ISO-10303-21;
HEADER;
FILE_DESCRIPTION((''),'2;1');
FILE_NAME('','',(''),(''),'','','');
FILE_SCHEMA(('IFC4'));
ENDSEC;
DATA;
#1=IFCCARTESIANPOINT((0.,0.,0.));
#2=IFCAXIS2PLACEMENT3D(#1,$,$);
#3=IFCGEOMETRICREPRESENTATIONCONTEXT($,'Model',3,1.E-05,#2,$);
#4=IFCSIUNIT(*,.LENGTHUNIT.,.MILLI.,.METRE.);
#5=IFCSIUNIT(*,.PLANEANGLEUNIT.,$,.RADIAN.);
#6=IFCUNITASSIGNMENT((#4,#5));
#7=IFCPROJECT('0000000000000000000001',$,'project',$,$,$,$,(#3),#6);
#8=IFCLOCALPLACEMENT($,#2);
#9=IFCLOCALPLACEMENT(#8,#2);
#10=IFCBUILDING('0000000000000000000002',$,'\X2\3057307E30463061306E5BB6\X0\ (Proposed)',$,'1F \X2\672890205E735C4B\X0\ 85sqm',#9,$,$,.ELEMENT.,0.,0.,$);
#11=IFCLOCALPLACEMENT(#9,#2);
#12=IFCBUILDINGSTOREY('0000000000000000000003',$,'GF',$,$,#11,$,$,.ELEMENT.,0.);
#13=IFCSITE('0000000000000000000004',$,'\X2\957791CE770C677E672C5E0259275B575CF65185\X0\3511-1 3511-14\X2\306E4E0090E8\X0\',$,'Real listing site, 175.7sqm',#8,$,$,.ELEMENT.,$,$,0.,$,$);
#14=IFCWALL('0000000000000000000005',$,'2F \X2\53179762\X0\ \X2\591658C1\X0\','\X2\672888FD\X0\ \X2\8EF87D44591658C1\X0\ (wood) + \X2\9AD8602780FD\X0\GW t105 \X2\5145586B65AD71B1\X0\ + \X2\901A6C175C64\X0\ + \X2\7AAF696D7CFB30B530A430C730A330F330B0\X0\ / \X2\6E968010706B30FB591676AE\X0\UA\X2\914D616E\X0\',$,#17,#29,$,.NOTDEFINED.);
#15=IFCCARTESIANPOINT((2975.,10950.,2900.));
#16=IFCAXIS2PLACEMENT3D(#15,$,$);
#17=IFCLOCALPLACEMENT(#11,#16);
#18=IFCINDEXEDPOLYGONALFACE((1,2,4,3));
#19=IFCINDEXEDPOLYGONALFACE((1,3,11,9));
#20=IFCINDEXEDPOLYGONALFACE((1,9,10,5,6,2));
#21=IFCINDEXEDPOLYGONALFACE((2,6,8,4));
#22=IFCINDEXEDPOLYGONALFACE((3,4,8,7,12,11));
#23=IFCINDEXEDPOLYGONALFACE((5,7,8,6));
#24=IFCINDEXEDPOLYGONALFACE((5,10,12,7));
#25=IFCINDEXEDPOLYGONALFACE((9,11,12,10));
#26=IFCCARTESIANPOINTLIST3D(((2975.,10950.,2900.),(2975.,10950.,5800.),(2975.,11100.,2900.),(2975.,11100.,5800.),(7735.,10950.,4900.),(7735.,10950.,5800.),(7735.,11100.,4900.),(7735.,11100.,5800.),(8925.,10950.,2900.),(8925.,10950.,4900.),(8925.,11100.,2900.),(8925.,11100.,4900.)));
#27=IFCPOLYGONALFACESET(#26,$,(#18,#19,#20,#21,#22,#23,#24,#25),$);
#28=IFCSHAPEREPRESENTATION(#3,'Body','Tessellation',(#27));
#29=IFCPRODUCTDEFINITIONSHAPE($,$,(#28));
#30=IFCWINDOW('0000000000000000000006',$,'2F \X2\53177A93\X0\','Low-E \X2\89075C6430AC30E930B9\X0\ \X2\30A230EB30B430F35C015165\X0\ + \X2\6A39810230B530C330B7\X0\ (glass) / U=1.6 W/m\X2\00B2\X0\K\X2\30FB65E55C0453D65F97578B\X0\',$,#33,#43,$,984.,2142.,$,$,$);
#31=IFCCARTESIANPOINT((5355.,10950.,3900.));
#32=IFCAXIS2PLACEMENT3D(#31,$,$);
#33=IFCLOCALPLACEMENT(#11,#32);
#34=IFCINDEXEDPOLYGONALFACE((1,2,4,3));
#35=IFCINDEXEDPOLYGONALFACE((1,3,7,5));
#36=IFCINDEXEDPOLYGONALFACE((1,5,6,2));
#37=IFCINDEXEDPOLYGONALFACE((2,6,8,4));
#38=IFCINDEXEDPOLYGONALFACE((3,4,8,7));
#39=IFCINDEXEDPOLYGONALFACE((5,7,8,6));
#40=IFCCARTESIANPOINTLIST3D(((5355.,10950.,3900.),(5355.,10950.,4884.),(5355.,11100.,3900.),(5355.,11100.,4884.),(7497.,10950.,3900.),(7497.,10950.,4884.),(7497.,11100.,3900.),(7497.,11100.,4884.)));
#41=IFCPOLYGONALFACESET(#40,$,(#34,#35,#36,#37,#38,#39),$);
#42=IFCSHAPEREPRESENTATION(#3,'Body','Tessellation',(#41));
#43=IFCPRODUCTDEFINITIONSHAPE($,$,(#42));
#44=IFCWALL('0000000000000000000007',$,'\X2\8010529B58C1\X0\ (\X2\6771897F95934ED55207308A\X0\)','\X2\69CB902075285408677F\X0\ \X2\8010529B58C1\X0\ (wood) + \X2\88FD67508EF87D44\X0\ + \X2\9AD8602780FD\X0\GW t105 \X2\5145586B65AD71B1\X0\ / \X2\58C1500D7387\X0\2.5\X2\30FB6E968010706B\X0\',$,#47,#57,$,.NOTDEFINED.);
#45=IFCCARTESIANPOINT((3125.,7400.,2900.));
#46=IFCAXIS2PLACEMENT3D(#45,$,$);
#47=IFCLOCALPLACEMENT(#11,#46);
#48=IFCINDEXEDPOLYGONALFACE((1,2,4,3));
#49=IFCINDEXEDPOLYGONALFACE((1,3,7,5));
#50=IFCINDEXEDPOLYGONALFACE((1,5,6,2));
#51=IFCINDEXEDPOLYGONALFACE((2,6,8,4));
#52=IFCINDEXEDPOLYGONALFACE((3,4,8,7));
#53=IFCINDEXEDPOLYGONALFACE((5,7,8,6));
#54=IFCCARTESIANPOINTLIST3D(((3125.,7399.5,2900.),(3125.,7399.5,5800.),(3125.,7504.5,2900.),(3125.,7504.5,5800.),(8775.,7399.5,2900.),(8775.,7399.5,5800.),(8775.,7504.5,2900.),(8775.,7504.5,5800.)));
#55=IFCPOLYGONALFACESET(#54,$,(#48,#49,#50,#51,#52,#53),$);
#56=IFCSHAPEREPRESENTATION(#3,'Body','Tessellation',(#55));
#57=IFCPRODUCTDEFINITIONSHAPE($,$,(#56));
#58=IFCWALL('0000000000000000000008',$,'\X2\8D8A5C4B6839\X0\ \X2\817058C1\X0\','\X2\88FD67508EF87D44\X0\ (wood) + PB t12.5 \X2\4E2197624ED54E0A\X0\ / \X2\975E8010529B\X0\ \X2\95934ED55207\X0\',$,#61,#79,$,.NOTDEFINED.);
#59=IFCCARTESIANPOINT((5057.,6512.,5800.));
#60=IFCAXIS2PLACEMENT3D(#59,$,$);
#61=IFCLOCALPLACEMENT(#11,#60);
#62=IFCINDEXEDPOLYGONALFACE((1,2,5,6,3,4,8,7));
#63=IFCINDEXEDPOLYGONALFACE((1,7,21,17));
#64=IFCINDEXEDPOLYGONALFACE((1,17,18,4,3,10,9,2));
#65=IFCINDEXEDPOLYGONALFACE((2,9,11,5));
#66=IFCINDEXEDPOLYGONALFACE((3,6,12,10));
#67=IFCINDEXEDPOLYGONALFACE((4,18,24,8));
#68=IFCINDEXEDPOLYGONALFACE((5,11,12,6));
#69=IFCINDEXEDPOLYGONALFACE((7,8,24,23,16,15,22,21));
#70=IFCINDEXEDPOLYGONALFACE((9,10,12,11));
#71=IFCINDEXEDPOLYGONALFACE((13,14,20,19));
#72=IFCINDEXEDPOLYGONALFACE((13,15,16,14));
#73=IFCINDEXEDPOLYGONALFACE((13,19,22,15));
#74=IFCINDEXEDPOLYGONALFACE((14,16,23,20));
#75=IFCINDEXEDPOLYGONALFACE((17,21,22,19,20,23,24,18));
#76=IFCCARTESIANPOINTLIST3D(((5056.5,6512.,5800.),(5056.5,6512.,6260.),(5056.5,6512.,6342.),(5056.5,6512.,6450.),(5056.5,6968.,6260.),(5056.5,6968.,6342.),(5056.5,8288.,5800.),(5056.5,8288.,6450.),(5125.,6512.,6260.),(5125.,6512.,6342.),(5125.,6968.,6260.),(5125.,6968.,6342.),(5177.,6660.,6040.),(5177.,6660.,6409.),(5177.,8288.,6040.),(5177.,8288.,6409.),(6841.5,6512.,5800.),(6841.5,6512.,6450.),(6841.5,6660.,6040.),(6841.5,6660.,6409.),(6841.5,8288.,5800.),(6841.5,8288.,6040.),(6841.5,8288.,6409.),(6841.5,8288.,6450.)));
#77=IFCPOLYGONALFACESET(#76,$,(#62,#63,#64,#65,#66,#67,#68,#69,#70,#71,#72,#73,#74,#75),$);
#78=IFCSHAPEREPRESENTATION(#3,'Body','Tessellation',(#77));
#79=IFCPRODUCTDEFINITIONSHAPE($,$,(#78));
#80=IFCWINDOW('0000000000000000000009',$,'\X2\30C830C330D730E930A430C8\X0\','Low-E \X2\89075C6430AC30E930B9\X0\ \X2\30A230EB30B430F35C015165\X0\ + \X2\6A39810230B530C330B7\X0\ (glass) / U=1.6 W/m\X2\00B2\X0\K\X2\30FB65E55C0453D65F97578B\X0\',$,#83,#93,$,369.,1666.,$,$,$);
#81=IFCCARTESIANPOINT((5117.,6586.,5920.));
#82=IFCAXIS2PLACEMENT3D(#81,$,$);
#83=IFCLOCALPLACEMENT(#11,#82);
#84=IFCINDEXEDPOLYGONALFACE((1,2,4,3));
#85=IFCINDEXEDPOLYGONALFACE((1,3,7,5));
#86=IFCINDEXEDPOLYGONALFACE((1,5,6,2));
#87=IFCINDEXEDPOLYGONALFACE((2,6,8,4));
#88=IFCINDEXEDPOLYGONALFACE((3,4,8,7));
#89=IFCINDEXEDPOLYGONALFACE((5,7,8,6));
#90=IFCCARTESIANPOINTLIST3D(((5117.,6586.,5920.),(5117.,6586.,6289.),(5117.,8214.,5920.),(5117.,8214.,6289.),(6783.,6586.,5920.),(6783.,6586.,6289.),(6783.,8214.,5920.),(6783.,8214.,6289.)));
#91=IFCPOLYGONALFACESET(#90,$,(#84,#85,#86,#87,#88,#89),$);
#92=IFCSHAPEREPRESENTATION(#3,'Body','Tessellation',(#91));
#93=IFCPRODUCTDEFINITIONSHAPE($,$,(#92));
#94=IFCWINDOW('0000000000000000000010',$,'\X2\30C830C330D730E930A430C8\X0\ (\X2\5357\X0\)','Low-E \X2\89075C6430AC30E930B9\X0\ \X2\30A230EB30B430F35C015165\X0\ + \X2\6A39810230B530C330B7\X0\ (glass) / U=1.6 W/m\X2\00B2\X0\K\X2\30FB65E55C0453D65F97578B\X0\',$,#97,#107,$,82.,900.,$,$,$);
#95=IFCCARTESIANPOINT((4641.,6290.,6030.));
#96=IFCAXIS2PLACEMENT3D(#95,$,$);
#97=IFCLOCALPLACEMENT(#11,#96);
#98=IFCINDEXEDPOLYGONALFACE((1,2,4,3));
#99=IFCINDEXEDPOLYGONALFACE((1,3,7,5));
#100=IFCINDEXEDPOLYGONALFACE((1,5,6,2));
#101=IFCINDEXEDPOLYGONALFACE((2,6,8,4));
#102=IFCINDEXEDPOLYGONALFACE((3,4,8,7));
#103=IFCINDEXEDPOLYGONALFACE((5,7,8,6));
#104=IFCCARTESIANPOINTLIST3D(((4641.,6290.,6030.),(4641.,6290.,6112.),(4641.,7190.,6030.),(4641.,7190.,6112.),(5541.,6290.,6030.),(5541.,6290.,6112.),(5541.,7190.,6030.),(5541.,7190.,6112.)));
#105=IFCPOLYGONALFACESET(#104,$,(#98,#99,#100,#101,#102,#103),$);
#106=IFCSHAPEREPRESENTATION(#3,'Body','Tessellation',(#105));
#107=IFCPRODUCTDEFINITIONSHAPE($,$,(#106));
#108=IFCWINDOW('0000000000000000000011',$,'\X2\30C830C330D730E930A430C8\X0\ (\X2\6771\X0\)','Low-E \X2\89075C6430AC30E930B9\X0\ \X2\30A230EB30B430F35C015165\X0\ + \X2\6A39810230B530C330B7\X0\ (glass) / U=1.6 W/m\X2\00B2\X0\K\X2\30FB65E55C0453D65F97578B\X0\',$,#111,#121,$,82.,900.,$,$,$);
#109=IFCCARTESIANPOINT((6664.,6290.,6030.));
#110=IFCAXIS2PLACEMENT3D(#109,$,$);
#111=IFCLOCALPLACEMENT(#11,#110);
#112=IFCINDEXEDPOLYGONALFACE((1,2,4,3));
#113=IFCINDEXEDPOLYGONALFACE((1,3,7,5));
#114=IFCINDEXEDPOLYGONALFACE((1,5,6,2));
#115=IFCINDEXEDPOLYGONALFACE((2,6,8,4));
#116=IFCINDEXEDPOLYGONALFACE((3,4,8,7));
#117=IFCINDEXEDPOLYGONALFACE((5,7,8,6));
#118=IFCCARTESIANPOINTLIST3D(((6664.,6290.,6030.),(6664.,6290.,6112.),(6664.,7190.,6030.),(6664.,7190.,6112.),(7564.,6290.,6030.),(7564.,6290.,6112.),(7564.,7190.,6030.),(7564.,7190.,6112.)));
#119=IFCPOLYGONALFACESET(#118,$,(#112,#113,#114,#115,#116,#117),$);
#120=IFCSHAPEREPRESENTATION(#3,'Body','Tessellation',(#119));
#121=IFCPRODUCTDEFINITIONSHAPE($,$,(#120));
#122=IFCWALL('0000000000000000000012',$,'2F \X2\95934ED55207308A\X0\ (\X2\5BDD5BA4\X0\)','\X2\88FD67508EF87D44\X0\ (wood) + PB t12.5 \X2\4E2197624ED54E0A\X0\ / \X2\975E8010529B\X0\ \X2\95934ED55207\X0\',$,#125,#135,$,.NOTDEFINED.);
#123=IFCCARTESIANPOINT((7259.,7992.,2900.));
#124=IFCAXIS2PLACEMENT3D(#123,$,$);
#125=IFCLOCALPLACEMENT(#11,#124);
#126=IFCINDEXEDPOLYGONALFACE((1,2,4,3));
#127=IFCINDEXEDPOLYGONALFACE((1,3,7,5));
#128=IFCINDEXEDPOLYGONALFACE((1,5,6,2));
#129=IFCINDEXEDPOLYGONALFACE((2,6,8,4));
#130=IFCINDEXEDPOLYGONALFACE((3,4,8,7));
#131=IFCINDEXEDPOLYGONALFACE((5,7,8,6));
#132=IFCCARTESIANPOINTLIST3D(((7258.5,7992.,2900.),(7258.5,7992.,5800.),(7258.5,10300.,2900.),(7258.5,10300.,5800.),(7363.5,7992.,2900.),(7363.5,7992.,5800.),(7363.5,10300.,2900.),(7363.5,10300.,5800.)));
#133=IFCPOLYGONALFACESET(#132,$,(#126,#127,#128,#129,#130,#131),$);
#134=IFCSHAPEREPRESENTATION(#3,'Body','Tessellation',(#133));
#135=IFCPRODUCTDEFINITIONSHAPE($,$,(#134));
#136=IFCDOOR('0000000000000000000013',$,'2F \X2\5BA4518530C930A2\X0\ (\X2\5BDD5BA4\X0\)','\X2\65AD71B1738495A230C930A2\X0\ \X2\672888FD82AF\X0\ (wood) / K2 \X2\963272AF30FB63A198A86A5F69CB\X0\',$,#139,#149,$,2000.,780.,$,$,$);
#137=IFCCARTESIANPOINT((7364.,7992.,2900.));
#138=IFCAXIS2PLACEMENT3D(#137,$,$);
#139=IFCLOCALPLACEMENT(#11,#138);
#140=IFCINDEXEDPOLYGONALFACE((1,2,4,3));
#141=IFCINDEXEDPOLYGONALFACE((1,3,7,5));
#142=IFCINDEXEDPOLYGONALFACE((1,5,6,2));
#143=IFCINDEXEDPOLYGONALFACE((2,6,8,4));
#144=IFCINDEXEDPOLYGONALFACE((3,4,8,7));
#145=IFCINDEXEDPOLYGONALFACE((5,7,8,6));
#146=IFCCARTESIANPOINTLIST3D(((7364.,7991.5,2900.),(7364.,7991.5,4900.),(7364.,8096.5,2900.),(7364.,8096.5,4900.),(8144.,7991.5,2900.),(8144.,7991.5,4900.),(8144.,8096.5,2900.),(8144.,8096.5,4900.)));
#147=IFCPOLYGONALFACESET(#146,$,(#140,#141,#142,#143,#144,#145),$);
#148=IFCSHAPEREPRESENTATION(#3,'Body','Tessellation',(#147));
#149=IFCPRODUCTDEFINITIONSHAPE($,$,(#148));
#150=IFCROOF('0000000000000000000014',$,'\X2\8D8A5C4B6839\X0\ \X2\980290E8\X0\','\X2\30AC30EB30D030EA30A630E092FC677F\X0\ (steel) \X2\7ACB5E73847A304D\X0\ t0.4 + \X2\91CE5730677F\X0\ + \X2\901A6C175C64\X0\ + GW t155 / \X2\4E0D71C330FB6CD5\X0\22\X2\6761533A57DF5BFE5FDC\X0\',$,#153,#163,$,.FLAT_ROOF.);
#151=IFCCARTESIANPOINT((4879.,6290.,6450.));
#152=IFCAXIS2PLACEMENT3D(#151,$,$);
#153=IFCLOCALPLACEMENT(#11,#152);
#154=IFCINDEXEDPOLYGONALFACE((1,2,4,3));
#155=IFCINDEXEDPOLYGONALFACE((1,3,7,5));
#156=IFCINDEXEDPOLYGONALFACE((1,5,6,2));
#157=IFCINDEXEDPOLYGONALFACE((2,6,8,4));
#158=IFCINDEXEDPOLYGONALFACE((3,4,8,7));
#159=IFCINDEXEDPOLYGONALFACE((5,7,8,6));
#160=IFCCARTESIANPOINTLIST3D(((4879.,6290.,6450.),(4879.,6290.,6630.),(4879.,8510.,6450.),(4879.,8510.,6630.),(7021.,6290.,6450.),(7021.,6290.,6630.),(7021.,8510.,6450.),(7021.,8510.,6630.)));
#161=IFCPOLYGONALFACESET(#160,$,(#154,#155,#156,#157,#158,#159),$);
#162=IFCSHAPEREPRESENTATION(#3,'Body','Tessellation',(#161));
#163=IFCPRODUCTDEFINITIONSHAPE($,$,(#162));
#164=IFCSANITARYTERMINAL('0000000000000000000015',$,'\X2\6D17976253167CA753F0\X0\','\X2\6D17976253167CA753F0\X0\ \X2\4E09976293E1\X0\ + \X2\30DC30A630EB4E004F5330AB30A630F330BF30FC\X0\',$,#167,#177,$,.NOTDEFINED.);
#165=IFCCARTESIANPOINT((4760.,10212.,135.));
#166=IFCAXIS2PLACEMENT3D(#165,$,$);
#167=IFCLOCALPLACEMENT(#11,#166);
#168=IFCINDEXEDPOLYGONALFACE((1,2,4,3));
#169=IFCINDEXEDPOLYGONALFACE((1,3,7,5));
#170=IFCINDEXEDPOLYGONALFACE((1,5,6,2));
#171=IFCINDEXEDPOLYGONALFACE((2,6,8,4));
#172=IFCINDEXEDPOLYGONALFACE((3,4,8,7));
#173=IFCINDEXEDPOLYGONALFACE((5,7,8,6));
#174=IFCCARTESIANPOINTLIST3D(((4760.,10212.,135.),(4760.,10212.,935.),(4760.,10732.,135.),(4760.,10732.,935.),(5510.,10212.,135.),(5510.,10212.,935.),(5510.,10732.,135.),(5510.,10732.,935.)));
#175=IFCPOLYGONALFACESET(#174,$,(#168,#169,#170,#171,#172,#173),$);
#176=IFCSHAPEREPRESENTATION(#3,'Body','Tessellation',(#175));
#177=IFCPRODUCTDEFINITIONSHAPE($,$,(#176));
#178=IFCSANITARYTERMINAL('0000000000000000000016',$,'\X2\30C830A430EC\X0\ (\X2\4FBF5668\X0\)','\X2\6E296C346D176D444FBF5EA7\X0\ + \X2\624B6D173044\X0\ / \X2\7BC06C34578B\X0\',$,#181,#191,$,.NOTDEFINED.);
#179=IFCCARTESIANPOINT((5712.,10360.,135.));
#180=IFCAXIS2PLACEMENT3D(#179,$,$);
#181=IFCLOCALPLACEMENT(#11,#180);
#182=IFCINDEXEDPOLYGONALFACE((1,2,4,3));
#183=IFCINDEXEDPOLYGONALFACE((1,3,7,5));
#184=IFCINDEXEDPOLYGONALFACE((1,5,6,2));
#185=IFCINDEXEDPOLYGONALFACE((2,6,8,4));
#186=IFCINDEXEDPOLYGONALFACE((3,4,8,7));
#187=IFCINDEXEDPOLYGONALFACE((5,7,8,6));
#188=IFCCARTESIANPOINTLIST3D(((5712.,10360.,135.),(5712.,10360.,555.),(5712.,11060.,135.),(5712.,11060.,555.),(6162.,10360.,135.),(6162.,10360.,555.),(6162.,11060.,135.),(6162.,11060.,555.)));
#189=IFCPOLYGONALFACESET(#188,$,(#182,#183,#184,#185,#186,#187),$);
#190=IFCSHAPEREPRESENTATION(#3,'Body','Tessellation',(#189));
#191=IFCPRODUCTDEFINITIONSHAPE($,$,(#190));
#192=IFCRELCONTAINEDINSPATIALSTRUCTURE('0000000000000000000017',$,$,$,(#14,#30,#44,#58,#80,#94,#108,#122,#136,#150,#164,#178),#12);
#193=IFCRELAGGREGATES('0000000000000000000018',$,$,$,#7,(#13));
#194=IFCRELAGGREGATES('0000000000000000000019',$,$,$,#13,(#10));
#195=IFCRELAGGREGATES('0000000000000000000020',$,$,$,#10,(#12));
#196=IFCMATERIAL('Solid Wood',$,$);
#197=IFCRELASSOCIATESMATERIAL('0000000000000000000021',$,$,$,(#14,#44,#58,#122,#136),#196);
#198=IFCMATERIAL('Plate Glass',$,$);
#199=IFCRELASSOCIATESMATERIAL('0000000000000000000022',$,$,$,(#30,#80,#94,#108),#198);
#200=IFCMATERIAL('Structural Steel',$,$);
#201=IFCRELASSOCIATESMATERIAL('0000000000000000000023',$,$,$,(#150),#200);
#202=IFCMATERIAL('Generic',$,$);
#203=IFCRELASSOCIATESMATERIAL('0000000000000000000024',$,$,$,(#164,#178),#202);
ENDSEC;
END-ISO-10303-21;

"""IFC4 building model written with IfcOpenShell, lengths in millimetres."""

from ifc_helpers import new_model, si_unit, frame, frame_2d, origin, place, context, project, spatial, rectangle, extrude, material, element, fill, save


model = new_model("IFC4")

# Units and contexts
model_context = context("Model", 3, precision=1e-05, world=origin())
ifc_project = project(units=[si_unit("LENGTHUNIT", "METRE", prefix="MILLI"), si_unit("PLANEANGLEUNIT", "RADIAN")], contexts=[model_context])

# Site, building, storey
site_placement = place(None, origin())
site = spatial("IfcSite", under=ifc_project, at=site_placement, Name="長野県松本市大字島内3511-1 3511-14の一部", ObjectType="Real listing site, 175.7sqm", CompositionType="ELEMENT", RefElevation=0.0)
building_placement = place(site_placement, origin())
building = spatial("IfcBuilding", under=site, at=building_placement, Name="しまうちの家 (Proposed)", ObjectType="1F 木造平屋 85sqm", CompositionType="ELEMENT", ElevationOfRefHeight=0.0, ElevationOfTerrain=0.0)
storey_placement = place(building_placement, origin())
storey = spatial("IfcBuildingStorey", under=building, at=storey_placement, Name="GF", CompositionType="ELEMENT", Elevation=0.0)

# Wall, opening, window
ifc_material_1 = material(Name="Solid Wood")
wall_1_placement = place(storey_placement, frame((2975.0, 10950.0, 2900.0)))
wall_1 = element("IfcWall", 1, at=wall_1_placement, inside=storey, material=ifc_material_1, Name="2F 北面 外壁", Description="木製 軸組外壁 (wood) + 高性能GW t105 充填断熱 + 通気層 + 窯業系サイディング / 準耐火・外皮UA配慮", PredefinedType="NOTDEFINED", context=model_context, shape_type="SweptSolid", body=[
    extrude(rectangle(XDim=5950.0, YDim=150.0, at=frame_2d((2975.0, 75.0))), frame((2975.0, 10950.0, 2900.0)), (0.0, 0.0, 1.0), 2900.0),
])
opening_1_placement = place(storey_placement, frame((5355.0, 10950.0, 3900.0)))
opening_1 = element("IfcOpeningElement", 2, at=opening_1_placement, cuts=wall_1, PredefinedType="NOTDEFINED", context=model_context, shape_type="SweptSolid", body=[
    extrude(rectangle(XDim=2142.0, YDim=150.0, at=frame_2d((1071.0, 75.0))), frame((5355.0, 10950.0, 3900.0)), (0.0, 0.0, 1.0), 984.0),
])
ifc_material_2 = material(Name="Plate Glass")
window_1_placement = place(storey_placement, frame((5355.0, 10950.0, 3900.0)))
window_1 = element("IfcWindow", 3, at=window_1_placement, inside=storey, material=ifc_material_2, Name="2F 北窓", Description="Low-E 複層ガラス アルゴン封入 + 樹脂サッシ (glass) / U=1.6 W/m²K・日射取得型", OverallHeight=984.0, OverallWidth=2142.0, context=model_context, shape_type="SweptSolid", body=[
    extrude(rectangle(XDim=2142.0, YDim=150.0, at=frame_2d((1071.0, 75.0))), frame((5355.0, 10950.0, 3900.0)), (0.0, 0.0, 1.0), 984.0),
])
fill(opening_1, window_1)

# Wall
wall_2_placement = place(storey_placement, frame((3125.0, 7400.0, 2900.0)))
element("IfcWall", 4, at=wall_2_placement, inside=storey, material=ifc_material_1, Name="耐力壁 (東西間仕切り)", Description="構造用合板 耐力壁 (wood) + 製材軸組 + 高性能GW t105 充填断熱 / 壁倍率2.5・準耐火", PredefinedType="NOTDEFINED", context=model_context, shape_type="SweptSolid", body=[
    extrude(rectangle(XDim=5650.0, YDim=105.0, at=frame_2d((2825.0, 52.0))), frame((3125.0, 7400.0, 2900.0)), (0.0, 0.0, 1.0), 2900.0),
])

# Wall, openings, windows
wall_3_placement = place(storey_placement, frame((5057.0, 6512.0, 5800.0)))
wall_3 = element("IfcWall", 5, at=wall_3_placement, inside=storey, material=ifc_material_1, Name="越屋根 腰壁", Description="製材軸組 (wood) + PB t12.5 両面仕上 / 非耐力 間仕切", PredefinedType="NOTDEFINED", context=model_context, shape_type="SweptSolid", body=[
    extrude(rectangle(XDim=1785.0, YDim=1776.0, at=frame_2d((892.0, 888.0))), frame((5057.0, 6512.0, 5800.0)), (0.0, 0.0, 1.0), 650.0),
])
opening_2_placement = place(storey_placement, frame((5117.0, 6586.0, 5920.0)))
opening_2 = element("IfcOpeningElement", 6, at=opening_2_placement, cuts=wall_3, PredefinedType="NOTDEFINED", context=model_context, shape_type="SweptSolid", body=[
    extrude(rectangle(XDim=1666.0, YDim=1628.0, at=frame_2d((833.0, 814.0))), frame((5117.0, 6586.0, 5920.0)), (0.0, 0.0, 1.0), 369.0),
])
opening_3_placement = place(storey_placement, frame((4641.0, 6290.0, 6030.0)))
opening_3 = element("IfcOpeningElement", 7, at=opening_3_placement, cuts=wall_3, PredefinedType="NOTDEFINED", context=model_context, shape_type="SweptSolid", body=[
    extrude(rectangle(XDim=900.0, YDim=900.0, at=frame_2d((450.0, 450.0))), frame((4641.0, 6290.0, 6030.0)), (0.0, 0.0, 1.0), 82.0),
])
opening_4_placement = place(storey_placement, frame((6664.0, 6290.0, 6030.0)))
opening_4 = element("IfcOpeningElement", 8, at=opening_4_placement, cuts=wall_3, PredefinedType="NOTDEFINED", context=model_context, shape_type="SweptSolid", body=[
    extrude(rectangle(XDim=900.0, YDim=900.0, at=frame_2d((450.0, 450.0))), frame((6664.0, 6290.0, 6030.0)), (0.0, 0.0, 1.0), 82.0),
])
window_2_placement = place(storey_placement, frame((5117.0, 6586.0, 5920.0)))
window_2 = element("IfcWindow", 9, at=window_2_placement, inside=storey, material=ifc_material_2, Name="トップライト", Description="Low-E 複層ガラス アルゴン封入 + 樹脂サッシ (glass) / U=1.6 W/m²K・日射取得型", OverallHeight=369.0, OverallWidth=1666.0, context=model_context, shape_type="SweptSolid", body=[
    extrude(rectangle(XDim=1666.0, YDim=1628.0, at=frame_2d((833.0, 814.0))), frame((5117.0, 6586.0, 5920.0)), (0.0, 0.0, 1.0), 369.0),
])
fill(opening_2, window_2)
window_3_placement = place(storey_placement, frame((4641.0, 6290.0, 6030.0)))
window_3 = element("IfcWindow", 10, at=window_3_placement, inside=storey, material=ifc_material_2, Name="トップライト (南)", Description="Low-E 複層ガラス アルゴン封入 + 樹脂サッシ (glass) / U=1.6 W/m²K・日射取得型", OverallHeight=82.0, OverallWidth=900.0, context=model_context, shape_type="SweptSolid", body=[
    extrude(rectangle(XDim=900.0, YDim=900.0, at=frame_2d((450.0, 450.0))), frame((4641.0, 6290.0, 6030.0)), (0.0, 0.0, 1.0), 82.0),
])
fill(opening_3, window_3)
window_4_placement = place(storey_placement, frame((6664.0, 6290.0, 6030.0)))
window_4 = element("IfcWindow", 11, at=window_4_placement, inside=storey, material=ifc_material_2, Name="トップライト (東)", Description="Low-E 複層ガラス アルゴン封入 + 樹脂サッシ (glass) / U=1.6 W/m²K・日射取得型", OverallHeight=82.0, OverallWidth=900.0, context=model_context, shape_type="SweptSolid", body=[
    extrude(rectangle(XDim=900.0, YDim=900.0, at=frame_2d((450.0, 450.0))), frame((6664.0, 6290.0, 6030.0)), (0.0, 0.0, 1.0), 82.0),
])
fill(opening_4, window_4)

# Wall
wall_4_placement = place(storey_placement, frame((7259.0, 7992.0, 2900.0)))
element("IfcWall", 12, at=wall_4_placement, inside=storey, material=ifc_material_1, Name="2F 間仕切り (寝室)", Description="製材軸組 (wood) + PB t12.5 両面仕上 / 非耐力 間仕切", PredefinedType="NOTDEFINED", context=model_context, shape_type="SweptSolid", body=[
    extrude(rectangle(XDim=105.0, YDim=2308.0, at=frame_2d((52.0, 1154.0))), frame((7259.0, 7992.0, 2900.0)), (0.0, 0.0, 1.0), 2900.0),
])

# Door
door_placement = place(storey_placement, frame((7364.0, 7992.0, 2900.0)))
element("IfcDoor", 13, at=door_placement, inside=storey, material=ifc_material_1, Name="2F 室内ドア (寝室)", Description="断熱玄関ドア 木製芯 (wood) / K2 防犯・採風機構", OverallHeight=2000.0, OverallWidth=780.0, context=model_context, shape_type="SweptSolid", body=[
    extrude(rectangle(XDim=780.0, YDim=105.0, at=frame_2d((390.0, 52.0))), frame((7364.0, 7992.0, 2900.0)), (0.0, 0.0, 1.0), 2000.0),
])

# Roof
ifc_material_3 = material(Name="Structural Steel")
roof_placement = place(storey_placement, frame((4879.0, 6290.0, 6450.0)))
element("IfcRoof", 14, at=roof_placement, inside=storey, material=ifc_material_3, Name="越屋根 頂部", Description="ガルバリウム鋼板 (steel) 立平葺き t0.4 + 野地板 + 通気層 + GW t155 / 不燃・法22条区域対応", PredefinedType="FLAT_ROOF", context=model_context, shape_type="SweptSolid", body=[
    extrude(rectangle(XDim=2142.0, YDim=2220.0, at=frame_2d((1071.0, 1110.0))), frame((4879.0, 6290.0, 6450.0)), (0.0, 0.0, 1.0), 180.0),
])

# Sanitary terminals
ifc_material_4 = material(Name="Generic")
sanitary_terminal_1_placement = place(storey_placement, frame((4760.0, 10212.0, 135.0)))
element("IfcSanitaryTerminal", 15, at=sanitary_terminal_1_placement, inside=storey, material=ifc_material_4, Name="洗面化粧台", Description="洗面化粧台 三面鏡 + ボウル一体カウンター", PredefinedType="NOTDEFINED", context=model_context, shape_type="SweptSolid", body=[
    extrude(rectangle(XDim=750.0, YDim=520.0, at=frame_2d((375.0, 260.0))), frame((4760.0, 10212.0, 135.0)), (0.0, 0.0, 1.0), 800.0),
])
sanitary_terminal_2_placement = place(storey_placement, frame((5712.0, 10360.0, 135.0)))
element("IfcSanitaryTerminal", 16, at=sanitary_terminal_2_placement, inside=storey, material=ifc_material_4, Name="トイレ (便器)", Description="温水洗浄便座 + 手洗い / 節水型", PredefinedType="NOTDEFINED", context=model_context, shape_type="SweptSolid", body=[
    extrude(rectangle(XDim=450.0, YDim=700.0, at=frame_2d((225.0, 350.0))), frame((5712.0, 10360.0, 135.0)), (0.0, 0.0, 1.0), 420.0),
])

save(model, "model.ifc")
